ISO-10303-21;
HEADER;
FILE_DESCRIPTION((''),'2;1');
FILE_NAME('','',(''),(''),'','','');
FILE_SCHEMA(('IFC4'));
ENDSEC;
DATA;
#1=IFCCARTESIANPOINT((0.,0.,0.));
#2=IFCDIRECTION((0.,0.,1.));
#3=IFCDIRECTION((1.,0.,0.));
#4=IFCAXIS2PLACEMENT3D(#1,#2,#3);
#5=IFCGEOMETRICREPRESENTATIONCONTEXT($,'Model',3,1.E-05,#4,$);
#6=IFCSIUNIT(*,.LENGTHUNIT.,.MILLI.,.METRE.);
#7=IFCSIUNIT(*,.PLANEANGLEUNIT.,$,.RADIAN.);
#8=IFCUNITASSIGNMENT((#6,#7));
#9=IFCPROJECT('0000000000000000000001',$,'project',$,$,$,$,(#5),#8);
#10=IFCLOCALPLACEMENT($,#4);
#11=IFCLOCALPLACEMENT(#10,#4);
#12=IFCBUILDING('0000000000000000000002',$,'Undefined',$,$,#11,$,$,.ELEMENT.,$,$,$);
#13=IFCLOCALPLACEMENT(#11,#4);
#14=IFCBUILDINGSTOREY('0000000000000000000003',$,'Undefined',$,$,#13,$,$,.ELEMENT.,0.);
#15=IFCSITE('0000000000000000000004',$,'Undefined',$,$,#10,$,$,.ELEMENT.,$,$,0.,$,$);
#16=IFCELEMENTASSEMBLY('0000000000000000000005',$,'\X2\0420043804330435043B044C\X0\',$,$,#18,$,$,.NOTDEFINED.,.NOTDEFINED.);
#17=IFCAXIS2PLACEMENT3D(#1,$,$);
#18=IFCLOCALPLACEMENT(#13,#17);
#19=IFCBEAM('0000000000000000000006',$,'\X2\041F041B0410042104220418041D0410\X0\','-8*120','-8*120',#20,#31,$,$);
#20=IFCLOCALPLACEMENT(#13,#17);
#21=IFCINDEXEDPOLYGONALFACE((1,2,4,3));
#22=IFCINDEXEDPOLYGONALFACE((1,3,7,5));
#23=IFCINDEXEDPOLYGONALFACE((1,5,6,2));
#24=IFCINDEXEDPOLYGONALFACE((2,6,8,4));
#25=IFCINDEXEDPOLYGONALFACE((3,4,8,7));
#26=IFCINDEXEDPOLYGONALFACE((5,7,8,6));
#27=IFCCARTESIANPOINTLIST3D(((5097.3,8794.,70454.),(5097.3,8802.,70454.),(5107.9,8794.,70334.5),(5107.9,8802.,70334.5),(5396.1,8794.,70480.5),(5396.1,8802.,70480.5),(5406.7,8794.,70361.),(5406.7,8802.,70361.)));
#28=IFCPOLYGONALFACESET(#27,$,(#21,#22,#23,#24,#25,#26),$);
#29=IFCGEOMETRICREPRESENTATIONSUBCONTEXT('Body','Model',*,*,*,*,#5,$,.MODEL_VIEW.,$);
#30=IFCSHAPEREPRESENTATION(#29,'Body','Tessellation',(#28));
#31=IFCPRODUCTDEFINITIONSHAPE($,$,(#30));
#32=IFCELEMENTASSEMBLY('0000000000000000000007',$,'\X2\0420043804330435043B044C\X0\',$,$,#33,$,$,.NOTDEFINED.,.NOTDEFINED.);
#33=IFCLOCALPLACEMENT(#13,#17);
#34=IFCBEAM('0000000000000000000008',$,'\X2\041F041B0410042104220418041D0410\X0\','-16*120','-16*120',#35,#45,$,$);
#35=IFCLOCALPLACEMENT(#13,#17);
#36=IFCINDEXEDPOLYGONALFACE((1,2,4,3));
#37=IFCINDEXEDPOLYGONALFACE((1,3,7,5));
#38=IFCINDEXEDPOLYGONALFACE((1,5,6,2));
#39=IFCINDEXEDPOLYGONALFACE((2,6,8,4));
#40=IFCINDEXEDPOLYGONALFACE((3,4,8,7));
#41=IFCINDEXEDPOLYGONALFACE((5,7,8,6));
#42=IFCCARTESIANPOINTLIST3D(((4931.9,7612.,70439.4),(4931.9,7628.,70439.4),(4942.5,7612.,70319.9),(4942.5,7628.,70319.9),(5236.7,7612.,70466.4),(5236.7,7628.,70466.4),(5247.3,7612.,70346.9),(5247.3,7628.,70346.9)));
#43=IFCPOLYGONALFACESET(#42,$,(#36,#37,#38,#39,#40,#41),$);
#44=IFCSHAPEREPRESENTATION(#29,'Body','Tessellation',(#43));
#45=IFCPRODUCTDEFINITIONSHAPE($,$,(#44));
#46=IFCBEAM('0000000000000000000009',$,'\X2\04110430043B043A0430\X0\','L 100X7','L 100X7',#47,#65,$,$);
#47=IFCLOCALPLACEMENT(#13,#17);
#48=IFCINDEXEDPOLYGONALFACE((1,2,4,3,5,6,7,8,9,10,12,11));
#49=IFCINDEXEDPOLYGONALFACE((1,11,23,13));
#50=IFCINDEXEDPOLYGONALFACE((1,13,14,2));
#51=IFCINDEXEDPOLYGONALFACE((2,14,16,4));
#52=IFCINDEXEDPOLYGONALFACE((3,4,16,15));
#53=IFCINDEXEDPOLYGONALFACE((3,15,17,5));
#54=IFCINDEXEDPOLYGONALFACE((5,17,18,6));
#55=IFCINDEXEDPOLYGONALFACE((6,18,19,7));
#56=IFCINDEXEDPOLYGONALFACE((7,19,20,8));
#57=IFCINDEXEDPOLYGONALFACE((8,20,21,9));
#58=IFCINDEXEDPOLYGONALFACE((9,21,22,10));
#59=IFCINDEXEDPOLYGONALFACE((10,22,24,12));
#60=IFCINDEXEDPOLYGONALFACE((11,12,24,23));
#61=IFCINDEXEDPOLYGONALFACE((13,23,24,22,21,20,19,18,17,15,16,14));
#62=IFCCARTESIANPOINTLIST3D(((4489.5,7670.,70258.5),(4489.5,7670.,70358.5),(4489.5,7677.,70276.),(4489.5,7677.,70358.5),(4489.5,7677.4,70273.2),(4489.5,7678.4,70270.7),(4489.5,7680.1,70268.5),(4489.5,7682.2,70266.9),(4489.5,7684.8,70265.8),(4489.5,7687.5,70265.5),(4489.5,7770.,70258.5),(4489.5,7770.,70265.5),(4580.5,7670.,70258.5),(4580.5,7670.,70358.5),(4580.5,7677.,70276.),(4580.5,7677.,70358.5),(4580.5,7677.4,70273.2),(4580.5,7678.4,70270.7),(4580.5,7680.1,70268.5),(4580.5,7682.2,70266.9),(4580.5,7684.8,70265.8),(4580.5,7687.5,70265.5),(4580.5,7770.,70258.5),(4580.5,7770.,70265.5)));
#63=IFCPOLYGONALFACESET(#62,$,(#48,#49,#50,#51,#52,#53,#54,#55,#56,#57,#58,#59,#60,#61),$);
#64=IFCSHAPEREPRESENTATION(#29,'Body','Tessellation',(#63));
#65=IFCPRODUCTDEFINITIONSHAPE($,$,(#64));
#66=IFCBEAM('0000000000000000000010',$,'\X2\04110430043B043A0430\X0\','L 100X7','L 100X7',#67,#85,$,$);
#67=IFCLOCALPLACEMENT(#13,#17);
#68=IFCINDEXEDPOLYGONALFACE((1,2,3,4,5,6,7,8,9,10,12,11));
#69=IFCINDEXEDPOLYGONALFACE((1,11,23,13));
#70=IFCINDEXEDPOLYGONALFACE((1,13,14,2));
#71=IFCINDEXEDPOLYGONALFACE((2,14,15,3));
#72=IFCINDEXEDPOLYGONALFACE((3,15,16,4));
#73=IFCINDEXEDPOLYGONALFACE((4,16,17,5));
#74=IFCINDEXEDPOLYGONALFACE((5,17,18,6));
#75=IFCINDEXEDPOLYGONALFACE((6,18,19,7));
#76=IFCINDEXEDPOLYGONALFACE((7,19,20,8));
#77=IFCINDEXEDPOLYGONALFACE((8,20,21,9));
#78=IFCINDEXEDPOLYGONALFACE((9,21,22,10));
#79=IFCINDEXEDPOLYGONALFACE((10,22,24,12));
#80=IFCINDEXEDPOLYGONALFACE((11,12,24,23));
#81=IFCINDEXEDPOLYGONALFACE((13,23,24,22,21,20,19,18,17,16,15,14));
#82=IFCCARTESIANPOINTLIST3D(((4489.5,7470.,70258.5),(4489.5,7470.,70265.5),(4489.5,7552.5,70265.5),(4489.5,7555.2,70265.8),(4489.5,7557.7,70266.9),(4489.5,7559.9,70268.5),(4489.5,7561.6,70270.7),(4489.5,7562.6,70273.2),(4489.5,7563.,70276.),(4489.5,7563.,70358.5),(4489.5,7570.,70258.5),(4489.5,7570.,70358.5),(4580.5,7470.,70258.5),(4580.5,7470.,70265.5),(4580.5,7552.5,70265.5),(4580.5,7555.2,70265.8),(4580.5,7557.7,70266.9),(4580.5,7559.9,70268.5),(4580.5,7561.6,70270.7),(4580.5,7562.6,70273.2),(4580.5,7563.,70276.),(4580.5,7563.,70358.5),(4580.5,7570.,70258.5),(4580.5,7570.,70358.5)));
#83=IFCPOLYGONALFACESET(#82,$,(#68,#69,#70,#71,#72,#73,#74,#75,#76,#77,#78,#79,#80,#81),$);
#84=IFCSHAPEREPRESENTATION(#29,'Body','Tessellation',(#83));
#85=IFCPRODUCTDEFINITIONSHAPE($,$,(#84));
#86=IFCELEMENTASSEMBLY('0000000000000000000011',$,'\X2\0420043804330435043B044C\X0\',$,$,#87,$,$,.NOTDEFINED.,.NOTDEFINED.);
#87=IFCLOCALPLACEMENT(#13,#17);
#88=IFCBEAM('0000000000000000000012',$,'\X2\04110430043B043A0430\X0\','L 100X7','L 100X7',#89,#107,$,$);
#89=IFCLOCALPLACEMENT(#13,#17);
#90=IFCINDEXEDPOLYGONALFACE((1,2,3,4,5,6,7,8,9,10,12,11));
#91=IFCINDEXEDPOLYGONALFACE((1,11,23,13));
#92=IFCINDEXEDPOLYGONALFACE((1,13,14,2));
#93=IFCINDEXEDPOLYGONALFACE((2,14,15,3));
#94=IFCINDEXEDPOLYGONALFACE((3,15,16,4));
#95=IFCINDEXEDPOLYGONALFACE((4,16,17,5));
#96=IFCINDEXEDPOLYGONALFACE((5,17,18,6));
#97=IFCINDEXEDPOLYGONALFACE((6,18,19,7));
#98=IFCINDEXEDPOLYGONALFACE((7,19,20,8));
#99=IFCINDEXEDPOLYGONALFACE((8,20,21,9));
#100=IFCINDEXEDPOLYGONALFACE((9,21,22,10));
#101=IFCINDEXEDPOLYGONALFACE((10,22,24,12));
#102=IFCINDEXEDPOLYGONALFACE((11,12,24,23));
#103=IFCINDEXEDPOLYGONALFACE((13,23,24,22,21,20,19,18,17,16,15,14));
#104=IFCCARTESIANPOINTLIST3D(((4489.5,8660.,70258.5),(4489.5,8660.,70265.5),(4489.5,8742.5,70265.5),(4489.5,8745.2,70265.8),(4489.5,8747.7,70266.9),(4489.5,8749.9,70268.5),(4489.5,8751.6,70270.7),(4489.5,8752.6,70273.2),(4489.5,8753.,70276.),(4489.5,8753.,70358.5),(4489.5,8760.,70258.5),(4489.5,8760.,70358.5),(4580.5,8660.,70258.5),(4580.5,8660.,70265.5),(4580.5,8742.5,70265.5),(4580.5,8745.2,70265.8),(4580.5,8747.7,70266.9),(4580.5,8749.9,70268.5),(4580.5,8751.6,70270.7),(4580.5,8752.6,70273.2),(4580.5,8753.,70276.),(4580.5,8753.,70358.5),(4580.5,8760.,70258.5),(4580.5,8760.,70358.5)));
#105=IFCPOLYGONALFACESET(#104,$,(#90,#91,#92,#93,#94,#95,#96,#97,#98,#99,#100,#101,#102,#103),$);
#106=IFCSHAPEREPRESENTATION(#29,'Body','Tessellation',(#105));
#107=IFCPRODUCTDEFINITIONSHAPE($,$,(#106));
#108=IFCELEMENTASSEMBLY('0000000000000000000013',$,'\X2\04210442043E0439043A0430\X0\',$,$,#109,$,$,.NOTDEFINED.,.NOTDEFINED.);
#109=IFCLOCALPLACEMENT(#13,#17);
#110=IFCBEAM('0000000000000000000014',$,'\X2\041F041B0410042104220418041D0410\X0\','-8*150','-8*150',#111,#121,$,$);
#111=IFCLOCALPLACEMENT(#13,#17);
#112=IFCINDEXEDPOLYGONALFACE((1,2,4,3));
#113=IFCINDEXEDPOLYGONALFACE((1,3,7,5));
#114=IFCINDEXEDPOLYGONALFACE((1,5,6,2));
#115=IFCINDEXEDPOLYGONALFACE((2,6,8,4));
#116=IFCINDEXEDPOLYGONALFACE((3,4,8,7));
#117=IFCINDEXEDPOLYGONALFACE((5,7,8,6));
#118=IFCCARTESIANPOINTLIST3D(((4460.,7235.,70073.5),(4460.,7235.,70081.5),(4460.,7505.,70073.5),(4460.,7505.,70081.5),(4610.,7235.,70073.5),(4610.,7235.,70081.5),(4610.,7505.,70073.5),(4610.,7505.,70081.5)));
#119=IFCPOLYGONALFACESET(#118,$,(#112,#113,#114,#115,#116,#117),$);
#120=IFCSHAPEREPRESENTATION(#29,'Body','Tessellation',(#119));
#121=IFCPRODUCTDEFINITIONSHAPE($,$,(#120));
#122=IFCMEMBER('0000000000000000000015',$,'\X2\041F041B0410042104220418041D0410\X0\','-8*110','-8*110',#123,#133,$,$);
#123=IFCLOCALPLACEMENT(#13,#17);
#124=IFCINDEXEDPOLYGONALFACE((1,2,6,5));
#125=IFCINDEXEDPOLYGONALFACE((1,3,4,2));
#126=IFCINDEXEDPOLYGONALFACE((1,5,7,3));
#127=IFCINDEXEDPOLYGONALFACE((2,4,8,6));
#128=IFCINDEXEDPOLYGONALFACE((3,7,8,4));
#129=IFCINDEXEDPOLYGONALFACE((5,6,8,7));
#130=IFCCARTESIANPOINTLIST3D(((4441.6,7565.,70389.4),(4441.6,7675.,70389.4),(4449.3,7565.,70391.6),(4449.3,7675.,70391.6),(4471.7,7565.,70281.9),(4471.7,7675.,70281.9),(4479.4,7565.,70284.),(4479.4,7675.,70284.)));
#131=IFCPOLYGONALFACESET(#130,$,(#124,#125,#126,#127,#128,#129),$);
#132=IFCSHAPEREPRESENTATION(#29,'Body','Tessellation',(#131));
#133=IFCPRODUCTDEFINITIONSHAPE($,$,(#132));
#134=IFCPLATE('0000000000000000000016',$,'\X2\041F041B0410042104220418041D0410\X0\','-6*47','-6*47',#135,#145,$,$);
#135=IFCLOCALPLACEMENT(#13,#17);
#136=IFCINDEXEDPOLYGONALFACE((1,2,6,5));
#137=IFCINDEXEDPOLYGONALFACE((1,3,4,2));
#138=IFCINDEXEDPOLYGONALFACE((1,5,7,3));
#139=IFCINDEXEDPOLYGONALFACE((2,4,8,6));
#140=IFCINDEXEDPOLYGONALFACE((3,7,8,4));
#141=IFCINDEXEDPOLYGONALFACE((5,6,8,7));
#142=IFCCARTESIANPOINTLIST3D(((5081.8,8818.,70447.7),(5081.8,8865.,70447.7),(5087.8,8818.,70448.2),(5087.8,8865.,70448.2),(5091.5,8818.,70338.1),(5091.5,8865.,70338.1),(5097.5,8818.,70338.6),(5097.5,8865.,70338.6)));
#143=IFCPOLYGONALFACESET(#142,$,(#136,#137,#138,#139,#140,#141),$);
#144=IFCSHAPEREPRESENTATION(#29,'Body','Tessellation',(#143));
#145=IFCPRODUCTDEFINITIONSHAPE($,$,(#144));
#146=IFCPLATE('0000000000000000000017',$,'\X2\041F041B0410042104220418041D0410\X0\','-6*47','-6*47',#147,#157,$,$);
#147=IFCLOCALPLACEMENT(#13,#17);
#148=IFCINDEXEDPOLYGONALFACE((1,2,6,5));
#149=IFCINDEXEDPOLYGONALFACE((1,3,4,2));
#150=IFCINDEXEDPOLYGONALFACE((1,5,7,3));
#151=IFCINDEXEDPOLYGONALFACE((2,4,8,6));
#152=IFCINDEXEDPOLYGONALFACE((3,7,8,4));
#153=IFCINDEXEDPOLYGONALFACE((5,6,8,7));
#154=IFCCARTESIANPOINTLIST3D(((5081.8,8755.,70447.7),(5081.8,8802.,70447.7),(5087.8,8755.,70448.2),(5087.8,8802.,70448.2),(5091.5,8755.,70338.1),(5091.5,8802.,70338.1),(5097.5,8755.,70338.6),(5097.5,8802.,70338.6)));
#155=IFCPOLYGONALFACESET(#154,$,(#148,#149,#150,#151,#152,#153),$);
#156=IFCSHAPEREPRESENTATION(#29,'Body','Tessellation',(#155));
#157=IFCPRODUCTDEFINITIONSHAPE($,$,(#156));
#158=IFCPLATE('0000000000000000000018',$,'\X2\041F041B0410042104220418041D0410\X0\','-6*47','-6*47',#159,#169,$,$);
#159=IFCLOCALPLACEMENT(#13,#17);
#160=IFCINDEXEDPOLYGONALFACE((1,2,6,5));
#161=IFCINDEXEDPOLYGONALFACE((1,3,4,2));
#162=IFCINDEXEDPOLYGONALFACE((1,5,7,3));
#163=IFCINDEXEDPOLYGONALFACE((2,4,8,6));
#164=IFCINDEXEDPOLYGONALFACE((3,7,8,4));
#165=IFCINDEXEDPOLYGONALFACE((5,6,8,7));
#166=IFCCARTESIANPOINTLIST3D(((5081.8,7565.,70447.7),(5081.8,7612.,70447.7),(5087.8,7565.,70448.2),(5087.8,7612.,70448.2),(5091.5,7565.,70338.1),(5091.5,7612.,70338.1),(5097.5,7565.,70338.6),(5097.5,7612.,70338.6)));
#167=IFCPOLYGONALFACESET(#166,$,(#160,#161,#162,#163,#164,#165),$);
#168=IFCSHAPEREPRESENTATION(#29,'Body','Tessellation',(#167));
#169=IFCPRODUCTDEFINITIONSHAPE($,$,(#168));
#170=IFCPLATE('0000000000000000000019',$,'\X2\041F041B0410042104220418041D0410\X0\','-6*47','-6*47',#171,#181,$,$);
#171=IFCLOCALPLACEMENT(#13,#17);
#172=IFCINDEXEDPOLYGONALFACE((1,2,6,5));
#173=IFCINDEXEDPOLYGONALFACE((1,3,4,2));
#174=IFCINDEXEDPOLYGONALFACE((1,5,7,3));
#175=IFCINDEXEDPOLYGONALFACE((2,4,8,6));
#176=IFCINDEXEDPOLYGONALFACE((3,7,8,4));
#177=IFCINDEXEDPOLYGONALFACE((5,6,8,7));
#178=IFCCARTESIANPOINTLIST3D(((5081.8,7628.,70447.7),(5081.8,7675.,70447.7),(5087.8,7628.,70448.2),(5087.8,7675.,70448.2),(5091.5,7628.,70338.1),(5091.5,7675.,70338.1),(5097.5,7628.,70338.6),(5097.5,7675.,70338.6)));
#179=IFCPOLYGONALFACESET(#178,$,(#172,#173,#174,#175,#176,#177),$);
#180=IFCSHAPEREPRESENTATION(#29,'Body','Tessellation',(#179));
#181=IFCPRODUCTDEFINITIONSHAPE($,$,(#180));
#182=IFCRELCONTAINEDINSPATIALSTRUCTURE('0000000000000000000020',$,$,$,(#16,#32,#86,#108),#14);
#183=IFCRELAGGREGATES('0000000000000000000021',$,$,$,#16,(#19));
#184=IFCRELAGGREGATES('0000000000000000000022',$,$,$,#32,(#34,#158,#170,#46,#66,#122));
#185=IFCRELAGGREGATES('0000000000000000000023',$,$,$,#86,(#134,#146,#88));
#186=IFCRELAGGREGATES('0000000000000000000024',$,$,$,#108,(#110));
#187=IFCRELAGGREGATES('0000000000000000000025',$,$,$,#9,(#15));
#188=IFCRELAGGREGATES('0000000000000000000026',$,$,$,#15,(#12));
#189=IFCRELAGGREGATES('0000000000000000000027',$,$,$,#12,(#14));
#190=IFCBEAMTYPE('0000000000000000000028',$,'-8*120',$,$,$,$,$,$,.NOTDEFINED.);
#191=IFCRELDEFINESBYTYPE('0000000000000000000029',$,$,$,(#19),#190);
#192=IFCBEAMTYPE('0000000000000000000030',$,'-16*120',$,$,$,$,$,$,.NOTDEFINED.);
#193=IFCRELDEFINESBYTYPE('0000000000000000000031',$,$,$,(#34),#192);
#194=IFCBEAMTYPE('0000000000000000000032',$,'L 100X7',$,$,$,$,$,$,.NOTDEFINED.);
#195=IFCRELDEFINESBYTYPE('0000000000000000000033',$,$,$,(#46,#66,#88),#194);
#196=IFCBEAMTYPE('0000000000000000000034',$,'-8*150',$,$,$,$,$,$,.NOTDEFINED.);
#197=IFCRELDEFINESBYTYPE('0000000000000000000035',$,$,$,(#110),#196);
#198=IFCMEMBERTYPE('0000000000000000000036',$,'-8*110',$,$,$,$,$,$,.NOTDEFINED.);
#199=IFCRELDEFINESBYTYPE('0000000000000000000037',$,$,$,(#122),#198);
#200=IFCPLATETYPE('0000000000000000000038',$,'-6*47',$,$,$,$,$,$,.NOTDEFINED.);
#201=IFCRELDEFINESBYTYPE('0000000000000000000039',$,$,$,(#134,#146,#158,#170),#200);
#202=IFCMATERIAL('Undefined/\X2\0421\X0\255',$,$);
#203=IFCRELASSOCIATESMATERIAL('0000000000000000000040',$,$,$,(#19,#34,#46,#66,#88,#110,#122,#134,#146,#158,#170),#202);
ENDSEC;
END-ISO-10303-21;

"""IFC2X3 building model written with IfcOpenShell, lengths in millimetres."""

from ifc_helpers import new_model, si_unit, frame, origin_with_axes, origin_2d_with_axis, place, context, subcontext, project, spatial, polyline, rectangle, l_section, outline, extrude, boolean, material, type_object, element, aggregate, save


model = new_model("IFC2X3")

# Units and contexts
model_context = context("Model", 3, precision=1e-05, world=origin_with_axes())
body_context = subcontext(model_context, "Body", "Model", "MODEL_VIEW")
ifc_project = project(units=[si_unit("LENGTHUNIT", "METRE", prefix="MILLI"), si_unit("PLANEANGLEUNIT", "RADIAN")], contexts=[model_context])

# Site, building, storey
site_placement = place(None, origin_with_axes())
site = spatial("IfcSite", under=ifc_project, at=site_placement, Name="Undefined", CompositionType="ELEMENT", RefElevation=0.0)
building_placement = place(site_placement, origin_with_axes())
building = spatial("IfcBuilding", under=site, at=building_placement, Name="Undefined", CompositionType="ELEMENT")
storey_placement = place(building_placement, origin_with_axes())
storey = spatial("IfcBuildingStorey", under=building, at=storey_placement, Name="Undefined", CompositionType="ELEMENT", Elevation=0.0)

# Element assembly, beam
assembly_1_placement = place(storey_placement, origin_with_axes())
assembly_1 = element("IfcElementAssembly", 1, at=assembly_1_placement, inside=storey, Name="Ригель", AssemblyPlace="NOTDEFINED", PredefinedType="NOTDEFINED")
ifc_material_1 = material(Name="Undefined/С255")
beam_type_1 = type_object("IfcBeamType", Name="-8*120", PredefinedType="NOTDEFINED")
beam_1_placement = place(assembly_1_placement, frame((5102.6, 8798.0, 70394.3), z_axis=(0.088152, 0.0, -0.996107), x_axis=(0.996107, 0.0, 0.088152)))
beam_1 = element("IfcBeam", 2, at=beam_1_placement, type_object=beam_type_1, material=ifc_material_1, Name="ПЛАСТИНА", Description="-8*120", ObjectType="-8*120", context=body_context, shape_type="SweptSolid", body=[
    extrude(rectangle(XDim=8.0, YDim=120.0, at=origin_2d_with_axis()), frame((300.0, 0.0, 0.0), z_axis=(-1.0, 0.0, 0.0), x_axis=(0.0, -1.0, 0.0)), (0.0, 0.0, 1.0), 300.0),
])
aggregate(assembly_1, [beam_1])

# Element assembly, beams
assembly_2_placement = place(storey_placement, origin_with_axes())
assembly_2 = element("IfcElementAssembly", 3, at=assembly_2_placement, inside=storey, Name="Ригель", AssemblyPlace="NOTDEFINED", PredefinedType="NOTDEFINED")
beam_type_2 = type_object("IfcBeamType", Name="-16*120", PredefinedType="NOTDEFINED")
beam_2_placement = place(assembly_2_placement, frame((4937.2, 7620.0, 70379.6), z_axis=(0.088152, 0.0, -0.996107), x_axis=(0.996107, 0.0, 0.088152)))
beam_2 = element("IfcBeam", 4, at=beam_2_placement, type_object=beam_type_2, material=ifc_material_1, Name="ПЛАСТИНА", Description="-16*120", ObjectType="-16*120", context=body_context, shape_type="SweptSolid", body=[
    extrude(rectangle(XDim=16.0, YDim=120.0, at=origin_2d_with_axis()), frame((306.0, 0.0, 0.0), z_axis=(-1.0, 0.0, 0.0), x_axis=(0.0, -1.0, 0.0)), (0.0, 0.0, 1.0), 306.0),
])
beam_type_3 = type_object("IfcBeamType", Name="L 100X7", PredefinedType="NOTDEFINED")
beam_3_placement = place(assembly_2_placement, frame((4489.5, 7720.0, 70308.5), z_axis=(0.0, 1.0, 0.0), x_axis=(1.0, 0.0, 0.0)))
beam_3 = element("IfcBeam", 5, at=beam_3_placement, type_object=beam_type_3, material=ifc_material_1, Name="Балка", Description="L 100X7", ObjectType="L 100X7", context=body_context, shape_type="SweptSolid", body=[
    extrude(l_section(Depth=100.0, Width=100.0, Thickness=7.0, FilletRadius=10.5, at=origin_2d_with_axis()), frame((91.0, 0.0, 0.0), z_axis=(-1.0, 0.0, 0.0), x_axis=(0.0, -1.0, 0.0)), (0.0, 0.0, 1.0), 91.0),
])
beam_4_placement = place(assembly_2_placement, frame((4489.5, 7520.0, 70308.5), z_axis=(0.0, 0.0, 1.0), x_axis=(1.0, 0.0, 0.0)))
beam_4 = element("IfcBeam", 6, at=beam_4_placement, type_object=beam_type_3, material=ifc_material_1, Name="Балка", Description="L 100X7", ObjectType="L 100X7", context=body_context, shape_type="SweptSolid", body=[
    extrude(l_section(Depth=100.0, Width=100.0, Thickness=7.0, FilletRadius=10.5, at=origin_2d_with_axis()), frame((91.0, 0.0, 0.0), z_axis=(-1.0, 0.0, 0.0), x_axis=(0.0, -1.0, 0.0)), (0.0, 0.0, 1.0), 91.0),
])

# Element assemblies, beams
assembly_3_placement = place(storey_placement, origin_with_axes())
assembly_3 = element("IfcElementAssembly", 7, at=assembly_3_placement, inside=storey, Name="Ригель", AssemblyPlace="NOTDEFINED", PredefinedType="NOTDEFINED")
beam_5_placement = place(assembly_3_placement, frame((4489.5, 8710.0, 70308.5), z_axis=(0.0, 0.0, 1.0), x_axis=(1.0, 0.0, 0.0)))
beam_5 = element("IfcBeam", 8, at=beam_5_placement, type_object=beam_type_3, material=ifc_material_1, Name="Балка", Description="L 100X7", ObjectType="L 100X7", context=body_context, shape_type="SweptSolid", body=[
    extrude(l_section(Depth=100.0, Width=100.0, Thickness=7.0, FilletRadius=10.5, at=origin_2d_with_axis()), frame((91.0, 0.0, 0.0), z_axis=(-1.0, 0.0, 0.0), x_axis=(0.0, -1.0, 0.0)), (0.0, 0.0, 1.0), 91.0),
])
assembly_4_placement = place(storey_placement, origin_with_axes())
assembly_4 = element("IfcElementAssembly", 9, at=assembly_4_placement, inside=storey, Name="Стойка", AssemblyPlace="NOTDEFINED", PredefinedType="NOTDEFINED")
beam_type_4 = type_object("IfcBeamType", Name="-8*150", PredefinedType="NOTDEFINED")
beam_6_placement = place(assembly_4_placement, frame((4535.0, 7505.0, 70077.5), z_axis=(-1.0, 0.0, 0.0), x_axis=(0.0, -1.0, 0.0)))
beam_6 = element("IfcBeam", 10, at=beam_6_placement, type_object=beam_type_4, material=ifc_material_1, Name="ПЛАСТИНА", Description="-8*150", ObjectType="-8*150", context=body_context, shape_type="SweptSolid", body=[
    extrude(rectangle(XDim=8.0, YDim=150.0, at=origin_2d_with_axis()), frame((270.0, 0.0, 0.0), z_axis=(-1.0, 0.0, 0.0), x_axis=(0.0, -1.0, 0.0)), (0.0, 0.0, 1.0), 270.0),
])

# Member
member_type = type_object("IfcMemberType", Name="-8*110", PredefinedType="NOTDEFINED")
member_placement = place(assembly_2_placement, frame((4475.6, 7620.0, 70282.9), z_axis=(0.0, -1.0, 0.0), x_axis=(-0.269248, 0.0, 0.963071)))
member = element("IfcMember", 11, at=member_placement, type_object=member_type, material=ifc_material_1, Name="ПЛАСТИНА", Description="-8*110", ObjectType="-8*110", context=body_context, shape_type="SweptSolid", body=[
    extrude(rectangle(XDim=8.0, YDim=110.0, at=origin_2d_with_axis()), frame((111.7, 0.0, 0.0), z_axis=(-1.0, 0.0, 0.0), x_axis=(0.0, -1.0, 0.0)), (0.0, 0.0, 1.0), 111.7),
])

# Plates
plate_type_1 = type_object("IfcPlateType", Name="-6*47", PredefinedType="NOTDEFINED")
plate_1_placement = place(assembly_3_placement, frame((5084.8, 8755.0, 70447.9), z_axis=(0.996107, 0.0, 0.088152), x_axis=(0.088152, 0.0, -0.996107)))
plate_1 = element("IfcPlate", 12, at=plate_1_placement, type_object=plate_type_1, material=ifc_material_1, Name="ПЛАСТИНА", Description="-6*47", ObjectType="-6*47", context=body_context, shape_type="CSG", body=[
    boolean("DIFFERENCE", extrude(outline(polyline([(0.0, 0.0), (110.0, 0.0), (110.0, 110.0), (0.0, 110.0), (0.0, 0.0)])), frame((0.0, 0.0, -3.0), z_axis=(0.0, 0.0, 1.0), x_axis=(1.0, 0.0, 0.0)), (0.0, 0.0, 1.0), 6.0), extrude(rectangle(XDim=26.0, YDim=130.0, at=origin_2d_with_axis()), frame((55.0, -3.0, 0.0), z_axis=(0.0, 1.0, 0.0), x_axis=(0.0, 0.0, -1.0)), (0.0, 0.0, 1.0), 66.0)),
])
plate_2_placement = place(assembly_3_placement, frame((5084.8, 8755.0, 70447.9), z_axis=(0.996107, 0.0, 0.088152), x_axis=(0.088152, 0.0, -0.996107)))
plate_2 = element("IfcPlate", 13, at=plate_2_placement, type_object=plate_type_1, material=ifc_material_1, Name="ПЛАСТИНА", Description="-6*47", ObjectType="-6*47", context=body_context, shape_type="CSG", body=[
    boolean("DIFFERENCE", extrude(outline(polyline([(0.0, 0.0), (110.0, 0.0), (110.0, 110.0), (0.0, 110.0), (0.0, 0.0)])), frame((0.0, 0.0, -3.0), z_axis=(0.0, 0.0, 1.0), x_axis=(1.0, 0.0, 0.0)), (0.0, 0.0, 1.0), 6.0), extrude(rectangle(XDim=26.0, YDim=130.0, at=origin_2d_with_axis()), frame((55.0, 47.0, 0.0), z_axis=(0.0, 1.0, 0.0), x_axis=(0.0, 0.0, -1.0)), (0.0, 0.0, 1.0), 66.0)),
])
plate_3_placement = place(assembly_2_placement, frame((5084.8, 7565.0, 70447.9), z_axis=(0.996107, 0.0, 0.088152), x_axis=(0.088152, 0.0, -0.996107)))
plate_3 = element("IfcPlate", 14, at=plate_3_placement, type_object=plate_type_1, material=ifc_material_1, Name="ПЛАСТИНА", Description="-6*47", ObjectType="-6*47", context=body_context, shape_type="CSG", body=[
    boolean("DIFFERENCE", extrude(outline(polyline([(0.0, 0.0), (110.0, 0.0), (110.0, 110.0), (0.0, 110.0), (0.0, 0.0)])), frame((0.0, 0.0, -3.0), z_axis=(0.0, 0.0, 1.0), x_axis=(1.0, 0.0, 0.0)), (0.0, 0.0, 1.0), 6.0), extrude(rectangle(XDim=26.0, YDim=130.0, at=origin_2d_with_axis()), frame((55.0, 47.0, 0.0), z_axis=(0.0, 1.0, 0.0), x_axis=(0.0, 0.0, -1.0)), (0.0, 0.0, 1.0), 66.0)),
])
plate_4_placement = place(assembly_2_placement, frame((5084.8, 7565.0, 70447.9), z_axis=(0.996107, 0.0, 0.088152), x_axis=(0.088152, 0.0, -0.996107)))
plate_4 = element("IfcPlate", 15, at=plate_4_placement, type_object=plate_type_1, material=ifc_material_1, Name="ПЛАСТИНА", Description="-6*47", ObjectType="-6*47", context=body_context, shape_type="CSG", body=[
    boolean("DIFFERENCE", extrude(outline(polyline([(0.0, 0.0), (110.0, 0.0), (110.0, 110.0), (0.0, 110.0), (0.0, 0.0)])), frame((0.0, 0.0, -3.0), z_axis=(0.0, 0.0, 1.0), x_axis=(1.0, 0.0, 0.0)), (0.0, 0.0, 1.0), 6.0), extrude(rectangle(XDim=26.0, YDim=130.0, at=origin_2d_with_axis()), frame((55.0, -3.0, 0.0), z_axis=(0.0, 1.0, 0.0), x_axis=(0.0, 0.0, -1.0)), (0.0, 0.0, 1.0), 66.0)),
])

aggregate(assembly_2, [beam_2, plate_3, plate_4, beam_3, beam_4, member])
aggregate(assembly_3, [plate_1, plate_2, beam_5])
aggregate(assembly_4, [beam_6])

save(model, "model.ifc")
